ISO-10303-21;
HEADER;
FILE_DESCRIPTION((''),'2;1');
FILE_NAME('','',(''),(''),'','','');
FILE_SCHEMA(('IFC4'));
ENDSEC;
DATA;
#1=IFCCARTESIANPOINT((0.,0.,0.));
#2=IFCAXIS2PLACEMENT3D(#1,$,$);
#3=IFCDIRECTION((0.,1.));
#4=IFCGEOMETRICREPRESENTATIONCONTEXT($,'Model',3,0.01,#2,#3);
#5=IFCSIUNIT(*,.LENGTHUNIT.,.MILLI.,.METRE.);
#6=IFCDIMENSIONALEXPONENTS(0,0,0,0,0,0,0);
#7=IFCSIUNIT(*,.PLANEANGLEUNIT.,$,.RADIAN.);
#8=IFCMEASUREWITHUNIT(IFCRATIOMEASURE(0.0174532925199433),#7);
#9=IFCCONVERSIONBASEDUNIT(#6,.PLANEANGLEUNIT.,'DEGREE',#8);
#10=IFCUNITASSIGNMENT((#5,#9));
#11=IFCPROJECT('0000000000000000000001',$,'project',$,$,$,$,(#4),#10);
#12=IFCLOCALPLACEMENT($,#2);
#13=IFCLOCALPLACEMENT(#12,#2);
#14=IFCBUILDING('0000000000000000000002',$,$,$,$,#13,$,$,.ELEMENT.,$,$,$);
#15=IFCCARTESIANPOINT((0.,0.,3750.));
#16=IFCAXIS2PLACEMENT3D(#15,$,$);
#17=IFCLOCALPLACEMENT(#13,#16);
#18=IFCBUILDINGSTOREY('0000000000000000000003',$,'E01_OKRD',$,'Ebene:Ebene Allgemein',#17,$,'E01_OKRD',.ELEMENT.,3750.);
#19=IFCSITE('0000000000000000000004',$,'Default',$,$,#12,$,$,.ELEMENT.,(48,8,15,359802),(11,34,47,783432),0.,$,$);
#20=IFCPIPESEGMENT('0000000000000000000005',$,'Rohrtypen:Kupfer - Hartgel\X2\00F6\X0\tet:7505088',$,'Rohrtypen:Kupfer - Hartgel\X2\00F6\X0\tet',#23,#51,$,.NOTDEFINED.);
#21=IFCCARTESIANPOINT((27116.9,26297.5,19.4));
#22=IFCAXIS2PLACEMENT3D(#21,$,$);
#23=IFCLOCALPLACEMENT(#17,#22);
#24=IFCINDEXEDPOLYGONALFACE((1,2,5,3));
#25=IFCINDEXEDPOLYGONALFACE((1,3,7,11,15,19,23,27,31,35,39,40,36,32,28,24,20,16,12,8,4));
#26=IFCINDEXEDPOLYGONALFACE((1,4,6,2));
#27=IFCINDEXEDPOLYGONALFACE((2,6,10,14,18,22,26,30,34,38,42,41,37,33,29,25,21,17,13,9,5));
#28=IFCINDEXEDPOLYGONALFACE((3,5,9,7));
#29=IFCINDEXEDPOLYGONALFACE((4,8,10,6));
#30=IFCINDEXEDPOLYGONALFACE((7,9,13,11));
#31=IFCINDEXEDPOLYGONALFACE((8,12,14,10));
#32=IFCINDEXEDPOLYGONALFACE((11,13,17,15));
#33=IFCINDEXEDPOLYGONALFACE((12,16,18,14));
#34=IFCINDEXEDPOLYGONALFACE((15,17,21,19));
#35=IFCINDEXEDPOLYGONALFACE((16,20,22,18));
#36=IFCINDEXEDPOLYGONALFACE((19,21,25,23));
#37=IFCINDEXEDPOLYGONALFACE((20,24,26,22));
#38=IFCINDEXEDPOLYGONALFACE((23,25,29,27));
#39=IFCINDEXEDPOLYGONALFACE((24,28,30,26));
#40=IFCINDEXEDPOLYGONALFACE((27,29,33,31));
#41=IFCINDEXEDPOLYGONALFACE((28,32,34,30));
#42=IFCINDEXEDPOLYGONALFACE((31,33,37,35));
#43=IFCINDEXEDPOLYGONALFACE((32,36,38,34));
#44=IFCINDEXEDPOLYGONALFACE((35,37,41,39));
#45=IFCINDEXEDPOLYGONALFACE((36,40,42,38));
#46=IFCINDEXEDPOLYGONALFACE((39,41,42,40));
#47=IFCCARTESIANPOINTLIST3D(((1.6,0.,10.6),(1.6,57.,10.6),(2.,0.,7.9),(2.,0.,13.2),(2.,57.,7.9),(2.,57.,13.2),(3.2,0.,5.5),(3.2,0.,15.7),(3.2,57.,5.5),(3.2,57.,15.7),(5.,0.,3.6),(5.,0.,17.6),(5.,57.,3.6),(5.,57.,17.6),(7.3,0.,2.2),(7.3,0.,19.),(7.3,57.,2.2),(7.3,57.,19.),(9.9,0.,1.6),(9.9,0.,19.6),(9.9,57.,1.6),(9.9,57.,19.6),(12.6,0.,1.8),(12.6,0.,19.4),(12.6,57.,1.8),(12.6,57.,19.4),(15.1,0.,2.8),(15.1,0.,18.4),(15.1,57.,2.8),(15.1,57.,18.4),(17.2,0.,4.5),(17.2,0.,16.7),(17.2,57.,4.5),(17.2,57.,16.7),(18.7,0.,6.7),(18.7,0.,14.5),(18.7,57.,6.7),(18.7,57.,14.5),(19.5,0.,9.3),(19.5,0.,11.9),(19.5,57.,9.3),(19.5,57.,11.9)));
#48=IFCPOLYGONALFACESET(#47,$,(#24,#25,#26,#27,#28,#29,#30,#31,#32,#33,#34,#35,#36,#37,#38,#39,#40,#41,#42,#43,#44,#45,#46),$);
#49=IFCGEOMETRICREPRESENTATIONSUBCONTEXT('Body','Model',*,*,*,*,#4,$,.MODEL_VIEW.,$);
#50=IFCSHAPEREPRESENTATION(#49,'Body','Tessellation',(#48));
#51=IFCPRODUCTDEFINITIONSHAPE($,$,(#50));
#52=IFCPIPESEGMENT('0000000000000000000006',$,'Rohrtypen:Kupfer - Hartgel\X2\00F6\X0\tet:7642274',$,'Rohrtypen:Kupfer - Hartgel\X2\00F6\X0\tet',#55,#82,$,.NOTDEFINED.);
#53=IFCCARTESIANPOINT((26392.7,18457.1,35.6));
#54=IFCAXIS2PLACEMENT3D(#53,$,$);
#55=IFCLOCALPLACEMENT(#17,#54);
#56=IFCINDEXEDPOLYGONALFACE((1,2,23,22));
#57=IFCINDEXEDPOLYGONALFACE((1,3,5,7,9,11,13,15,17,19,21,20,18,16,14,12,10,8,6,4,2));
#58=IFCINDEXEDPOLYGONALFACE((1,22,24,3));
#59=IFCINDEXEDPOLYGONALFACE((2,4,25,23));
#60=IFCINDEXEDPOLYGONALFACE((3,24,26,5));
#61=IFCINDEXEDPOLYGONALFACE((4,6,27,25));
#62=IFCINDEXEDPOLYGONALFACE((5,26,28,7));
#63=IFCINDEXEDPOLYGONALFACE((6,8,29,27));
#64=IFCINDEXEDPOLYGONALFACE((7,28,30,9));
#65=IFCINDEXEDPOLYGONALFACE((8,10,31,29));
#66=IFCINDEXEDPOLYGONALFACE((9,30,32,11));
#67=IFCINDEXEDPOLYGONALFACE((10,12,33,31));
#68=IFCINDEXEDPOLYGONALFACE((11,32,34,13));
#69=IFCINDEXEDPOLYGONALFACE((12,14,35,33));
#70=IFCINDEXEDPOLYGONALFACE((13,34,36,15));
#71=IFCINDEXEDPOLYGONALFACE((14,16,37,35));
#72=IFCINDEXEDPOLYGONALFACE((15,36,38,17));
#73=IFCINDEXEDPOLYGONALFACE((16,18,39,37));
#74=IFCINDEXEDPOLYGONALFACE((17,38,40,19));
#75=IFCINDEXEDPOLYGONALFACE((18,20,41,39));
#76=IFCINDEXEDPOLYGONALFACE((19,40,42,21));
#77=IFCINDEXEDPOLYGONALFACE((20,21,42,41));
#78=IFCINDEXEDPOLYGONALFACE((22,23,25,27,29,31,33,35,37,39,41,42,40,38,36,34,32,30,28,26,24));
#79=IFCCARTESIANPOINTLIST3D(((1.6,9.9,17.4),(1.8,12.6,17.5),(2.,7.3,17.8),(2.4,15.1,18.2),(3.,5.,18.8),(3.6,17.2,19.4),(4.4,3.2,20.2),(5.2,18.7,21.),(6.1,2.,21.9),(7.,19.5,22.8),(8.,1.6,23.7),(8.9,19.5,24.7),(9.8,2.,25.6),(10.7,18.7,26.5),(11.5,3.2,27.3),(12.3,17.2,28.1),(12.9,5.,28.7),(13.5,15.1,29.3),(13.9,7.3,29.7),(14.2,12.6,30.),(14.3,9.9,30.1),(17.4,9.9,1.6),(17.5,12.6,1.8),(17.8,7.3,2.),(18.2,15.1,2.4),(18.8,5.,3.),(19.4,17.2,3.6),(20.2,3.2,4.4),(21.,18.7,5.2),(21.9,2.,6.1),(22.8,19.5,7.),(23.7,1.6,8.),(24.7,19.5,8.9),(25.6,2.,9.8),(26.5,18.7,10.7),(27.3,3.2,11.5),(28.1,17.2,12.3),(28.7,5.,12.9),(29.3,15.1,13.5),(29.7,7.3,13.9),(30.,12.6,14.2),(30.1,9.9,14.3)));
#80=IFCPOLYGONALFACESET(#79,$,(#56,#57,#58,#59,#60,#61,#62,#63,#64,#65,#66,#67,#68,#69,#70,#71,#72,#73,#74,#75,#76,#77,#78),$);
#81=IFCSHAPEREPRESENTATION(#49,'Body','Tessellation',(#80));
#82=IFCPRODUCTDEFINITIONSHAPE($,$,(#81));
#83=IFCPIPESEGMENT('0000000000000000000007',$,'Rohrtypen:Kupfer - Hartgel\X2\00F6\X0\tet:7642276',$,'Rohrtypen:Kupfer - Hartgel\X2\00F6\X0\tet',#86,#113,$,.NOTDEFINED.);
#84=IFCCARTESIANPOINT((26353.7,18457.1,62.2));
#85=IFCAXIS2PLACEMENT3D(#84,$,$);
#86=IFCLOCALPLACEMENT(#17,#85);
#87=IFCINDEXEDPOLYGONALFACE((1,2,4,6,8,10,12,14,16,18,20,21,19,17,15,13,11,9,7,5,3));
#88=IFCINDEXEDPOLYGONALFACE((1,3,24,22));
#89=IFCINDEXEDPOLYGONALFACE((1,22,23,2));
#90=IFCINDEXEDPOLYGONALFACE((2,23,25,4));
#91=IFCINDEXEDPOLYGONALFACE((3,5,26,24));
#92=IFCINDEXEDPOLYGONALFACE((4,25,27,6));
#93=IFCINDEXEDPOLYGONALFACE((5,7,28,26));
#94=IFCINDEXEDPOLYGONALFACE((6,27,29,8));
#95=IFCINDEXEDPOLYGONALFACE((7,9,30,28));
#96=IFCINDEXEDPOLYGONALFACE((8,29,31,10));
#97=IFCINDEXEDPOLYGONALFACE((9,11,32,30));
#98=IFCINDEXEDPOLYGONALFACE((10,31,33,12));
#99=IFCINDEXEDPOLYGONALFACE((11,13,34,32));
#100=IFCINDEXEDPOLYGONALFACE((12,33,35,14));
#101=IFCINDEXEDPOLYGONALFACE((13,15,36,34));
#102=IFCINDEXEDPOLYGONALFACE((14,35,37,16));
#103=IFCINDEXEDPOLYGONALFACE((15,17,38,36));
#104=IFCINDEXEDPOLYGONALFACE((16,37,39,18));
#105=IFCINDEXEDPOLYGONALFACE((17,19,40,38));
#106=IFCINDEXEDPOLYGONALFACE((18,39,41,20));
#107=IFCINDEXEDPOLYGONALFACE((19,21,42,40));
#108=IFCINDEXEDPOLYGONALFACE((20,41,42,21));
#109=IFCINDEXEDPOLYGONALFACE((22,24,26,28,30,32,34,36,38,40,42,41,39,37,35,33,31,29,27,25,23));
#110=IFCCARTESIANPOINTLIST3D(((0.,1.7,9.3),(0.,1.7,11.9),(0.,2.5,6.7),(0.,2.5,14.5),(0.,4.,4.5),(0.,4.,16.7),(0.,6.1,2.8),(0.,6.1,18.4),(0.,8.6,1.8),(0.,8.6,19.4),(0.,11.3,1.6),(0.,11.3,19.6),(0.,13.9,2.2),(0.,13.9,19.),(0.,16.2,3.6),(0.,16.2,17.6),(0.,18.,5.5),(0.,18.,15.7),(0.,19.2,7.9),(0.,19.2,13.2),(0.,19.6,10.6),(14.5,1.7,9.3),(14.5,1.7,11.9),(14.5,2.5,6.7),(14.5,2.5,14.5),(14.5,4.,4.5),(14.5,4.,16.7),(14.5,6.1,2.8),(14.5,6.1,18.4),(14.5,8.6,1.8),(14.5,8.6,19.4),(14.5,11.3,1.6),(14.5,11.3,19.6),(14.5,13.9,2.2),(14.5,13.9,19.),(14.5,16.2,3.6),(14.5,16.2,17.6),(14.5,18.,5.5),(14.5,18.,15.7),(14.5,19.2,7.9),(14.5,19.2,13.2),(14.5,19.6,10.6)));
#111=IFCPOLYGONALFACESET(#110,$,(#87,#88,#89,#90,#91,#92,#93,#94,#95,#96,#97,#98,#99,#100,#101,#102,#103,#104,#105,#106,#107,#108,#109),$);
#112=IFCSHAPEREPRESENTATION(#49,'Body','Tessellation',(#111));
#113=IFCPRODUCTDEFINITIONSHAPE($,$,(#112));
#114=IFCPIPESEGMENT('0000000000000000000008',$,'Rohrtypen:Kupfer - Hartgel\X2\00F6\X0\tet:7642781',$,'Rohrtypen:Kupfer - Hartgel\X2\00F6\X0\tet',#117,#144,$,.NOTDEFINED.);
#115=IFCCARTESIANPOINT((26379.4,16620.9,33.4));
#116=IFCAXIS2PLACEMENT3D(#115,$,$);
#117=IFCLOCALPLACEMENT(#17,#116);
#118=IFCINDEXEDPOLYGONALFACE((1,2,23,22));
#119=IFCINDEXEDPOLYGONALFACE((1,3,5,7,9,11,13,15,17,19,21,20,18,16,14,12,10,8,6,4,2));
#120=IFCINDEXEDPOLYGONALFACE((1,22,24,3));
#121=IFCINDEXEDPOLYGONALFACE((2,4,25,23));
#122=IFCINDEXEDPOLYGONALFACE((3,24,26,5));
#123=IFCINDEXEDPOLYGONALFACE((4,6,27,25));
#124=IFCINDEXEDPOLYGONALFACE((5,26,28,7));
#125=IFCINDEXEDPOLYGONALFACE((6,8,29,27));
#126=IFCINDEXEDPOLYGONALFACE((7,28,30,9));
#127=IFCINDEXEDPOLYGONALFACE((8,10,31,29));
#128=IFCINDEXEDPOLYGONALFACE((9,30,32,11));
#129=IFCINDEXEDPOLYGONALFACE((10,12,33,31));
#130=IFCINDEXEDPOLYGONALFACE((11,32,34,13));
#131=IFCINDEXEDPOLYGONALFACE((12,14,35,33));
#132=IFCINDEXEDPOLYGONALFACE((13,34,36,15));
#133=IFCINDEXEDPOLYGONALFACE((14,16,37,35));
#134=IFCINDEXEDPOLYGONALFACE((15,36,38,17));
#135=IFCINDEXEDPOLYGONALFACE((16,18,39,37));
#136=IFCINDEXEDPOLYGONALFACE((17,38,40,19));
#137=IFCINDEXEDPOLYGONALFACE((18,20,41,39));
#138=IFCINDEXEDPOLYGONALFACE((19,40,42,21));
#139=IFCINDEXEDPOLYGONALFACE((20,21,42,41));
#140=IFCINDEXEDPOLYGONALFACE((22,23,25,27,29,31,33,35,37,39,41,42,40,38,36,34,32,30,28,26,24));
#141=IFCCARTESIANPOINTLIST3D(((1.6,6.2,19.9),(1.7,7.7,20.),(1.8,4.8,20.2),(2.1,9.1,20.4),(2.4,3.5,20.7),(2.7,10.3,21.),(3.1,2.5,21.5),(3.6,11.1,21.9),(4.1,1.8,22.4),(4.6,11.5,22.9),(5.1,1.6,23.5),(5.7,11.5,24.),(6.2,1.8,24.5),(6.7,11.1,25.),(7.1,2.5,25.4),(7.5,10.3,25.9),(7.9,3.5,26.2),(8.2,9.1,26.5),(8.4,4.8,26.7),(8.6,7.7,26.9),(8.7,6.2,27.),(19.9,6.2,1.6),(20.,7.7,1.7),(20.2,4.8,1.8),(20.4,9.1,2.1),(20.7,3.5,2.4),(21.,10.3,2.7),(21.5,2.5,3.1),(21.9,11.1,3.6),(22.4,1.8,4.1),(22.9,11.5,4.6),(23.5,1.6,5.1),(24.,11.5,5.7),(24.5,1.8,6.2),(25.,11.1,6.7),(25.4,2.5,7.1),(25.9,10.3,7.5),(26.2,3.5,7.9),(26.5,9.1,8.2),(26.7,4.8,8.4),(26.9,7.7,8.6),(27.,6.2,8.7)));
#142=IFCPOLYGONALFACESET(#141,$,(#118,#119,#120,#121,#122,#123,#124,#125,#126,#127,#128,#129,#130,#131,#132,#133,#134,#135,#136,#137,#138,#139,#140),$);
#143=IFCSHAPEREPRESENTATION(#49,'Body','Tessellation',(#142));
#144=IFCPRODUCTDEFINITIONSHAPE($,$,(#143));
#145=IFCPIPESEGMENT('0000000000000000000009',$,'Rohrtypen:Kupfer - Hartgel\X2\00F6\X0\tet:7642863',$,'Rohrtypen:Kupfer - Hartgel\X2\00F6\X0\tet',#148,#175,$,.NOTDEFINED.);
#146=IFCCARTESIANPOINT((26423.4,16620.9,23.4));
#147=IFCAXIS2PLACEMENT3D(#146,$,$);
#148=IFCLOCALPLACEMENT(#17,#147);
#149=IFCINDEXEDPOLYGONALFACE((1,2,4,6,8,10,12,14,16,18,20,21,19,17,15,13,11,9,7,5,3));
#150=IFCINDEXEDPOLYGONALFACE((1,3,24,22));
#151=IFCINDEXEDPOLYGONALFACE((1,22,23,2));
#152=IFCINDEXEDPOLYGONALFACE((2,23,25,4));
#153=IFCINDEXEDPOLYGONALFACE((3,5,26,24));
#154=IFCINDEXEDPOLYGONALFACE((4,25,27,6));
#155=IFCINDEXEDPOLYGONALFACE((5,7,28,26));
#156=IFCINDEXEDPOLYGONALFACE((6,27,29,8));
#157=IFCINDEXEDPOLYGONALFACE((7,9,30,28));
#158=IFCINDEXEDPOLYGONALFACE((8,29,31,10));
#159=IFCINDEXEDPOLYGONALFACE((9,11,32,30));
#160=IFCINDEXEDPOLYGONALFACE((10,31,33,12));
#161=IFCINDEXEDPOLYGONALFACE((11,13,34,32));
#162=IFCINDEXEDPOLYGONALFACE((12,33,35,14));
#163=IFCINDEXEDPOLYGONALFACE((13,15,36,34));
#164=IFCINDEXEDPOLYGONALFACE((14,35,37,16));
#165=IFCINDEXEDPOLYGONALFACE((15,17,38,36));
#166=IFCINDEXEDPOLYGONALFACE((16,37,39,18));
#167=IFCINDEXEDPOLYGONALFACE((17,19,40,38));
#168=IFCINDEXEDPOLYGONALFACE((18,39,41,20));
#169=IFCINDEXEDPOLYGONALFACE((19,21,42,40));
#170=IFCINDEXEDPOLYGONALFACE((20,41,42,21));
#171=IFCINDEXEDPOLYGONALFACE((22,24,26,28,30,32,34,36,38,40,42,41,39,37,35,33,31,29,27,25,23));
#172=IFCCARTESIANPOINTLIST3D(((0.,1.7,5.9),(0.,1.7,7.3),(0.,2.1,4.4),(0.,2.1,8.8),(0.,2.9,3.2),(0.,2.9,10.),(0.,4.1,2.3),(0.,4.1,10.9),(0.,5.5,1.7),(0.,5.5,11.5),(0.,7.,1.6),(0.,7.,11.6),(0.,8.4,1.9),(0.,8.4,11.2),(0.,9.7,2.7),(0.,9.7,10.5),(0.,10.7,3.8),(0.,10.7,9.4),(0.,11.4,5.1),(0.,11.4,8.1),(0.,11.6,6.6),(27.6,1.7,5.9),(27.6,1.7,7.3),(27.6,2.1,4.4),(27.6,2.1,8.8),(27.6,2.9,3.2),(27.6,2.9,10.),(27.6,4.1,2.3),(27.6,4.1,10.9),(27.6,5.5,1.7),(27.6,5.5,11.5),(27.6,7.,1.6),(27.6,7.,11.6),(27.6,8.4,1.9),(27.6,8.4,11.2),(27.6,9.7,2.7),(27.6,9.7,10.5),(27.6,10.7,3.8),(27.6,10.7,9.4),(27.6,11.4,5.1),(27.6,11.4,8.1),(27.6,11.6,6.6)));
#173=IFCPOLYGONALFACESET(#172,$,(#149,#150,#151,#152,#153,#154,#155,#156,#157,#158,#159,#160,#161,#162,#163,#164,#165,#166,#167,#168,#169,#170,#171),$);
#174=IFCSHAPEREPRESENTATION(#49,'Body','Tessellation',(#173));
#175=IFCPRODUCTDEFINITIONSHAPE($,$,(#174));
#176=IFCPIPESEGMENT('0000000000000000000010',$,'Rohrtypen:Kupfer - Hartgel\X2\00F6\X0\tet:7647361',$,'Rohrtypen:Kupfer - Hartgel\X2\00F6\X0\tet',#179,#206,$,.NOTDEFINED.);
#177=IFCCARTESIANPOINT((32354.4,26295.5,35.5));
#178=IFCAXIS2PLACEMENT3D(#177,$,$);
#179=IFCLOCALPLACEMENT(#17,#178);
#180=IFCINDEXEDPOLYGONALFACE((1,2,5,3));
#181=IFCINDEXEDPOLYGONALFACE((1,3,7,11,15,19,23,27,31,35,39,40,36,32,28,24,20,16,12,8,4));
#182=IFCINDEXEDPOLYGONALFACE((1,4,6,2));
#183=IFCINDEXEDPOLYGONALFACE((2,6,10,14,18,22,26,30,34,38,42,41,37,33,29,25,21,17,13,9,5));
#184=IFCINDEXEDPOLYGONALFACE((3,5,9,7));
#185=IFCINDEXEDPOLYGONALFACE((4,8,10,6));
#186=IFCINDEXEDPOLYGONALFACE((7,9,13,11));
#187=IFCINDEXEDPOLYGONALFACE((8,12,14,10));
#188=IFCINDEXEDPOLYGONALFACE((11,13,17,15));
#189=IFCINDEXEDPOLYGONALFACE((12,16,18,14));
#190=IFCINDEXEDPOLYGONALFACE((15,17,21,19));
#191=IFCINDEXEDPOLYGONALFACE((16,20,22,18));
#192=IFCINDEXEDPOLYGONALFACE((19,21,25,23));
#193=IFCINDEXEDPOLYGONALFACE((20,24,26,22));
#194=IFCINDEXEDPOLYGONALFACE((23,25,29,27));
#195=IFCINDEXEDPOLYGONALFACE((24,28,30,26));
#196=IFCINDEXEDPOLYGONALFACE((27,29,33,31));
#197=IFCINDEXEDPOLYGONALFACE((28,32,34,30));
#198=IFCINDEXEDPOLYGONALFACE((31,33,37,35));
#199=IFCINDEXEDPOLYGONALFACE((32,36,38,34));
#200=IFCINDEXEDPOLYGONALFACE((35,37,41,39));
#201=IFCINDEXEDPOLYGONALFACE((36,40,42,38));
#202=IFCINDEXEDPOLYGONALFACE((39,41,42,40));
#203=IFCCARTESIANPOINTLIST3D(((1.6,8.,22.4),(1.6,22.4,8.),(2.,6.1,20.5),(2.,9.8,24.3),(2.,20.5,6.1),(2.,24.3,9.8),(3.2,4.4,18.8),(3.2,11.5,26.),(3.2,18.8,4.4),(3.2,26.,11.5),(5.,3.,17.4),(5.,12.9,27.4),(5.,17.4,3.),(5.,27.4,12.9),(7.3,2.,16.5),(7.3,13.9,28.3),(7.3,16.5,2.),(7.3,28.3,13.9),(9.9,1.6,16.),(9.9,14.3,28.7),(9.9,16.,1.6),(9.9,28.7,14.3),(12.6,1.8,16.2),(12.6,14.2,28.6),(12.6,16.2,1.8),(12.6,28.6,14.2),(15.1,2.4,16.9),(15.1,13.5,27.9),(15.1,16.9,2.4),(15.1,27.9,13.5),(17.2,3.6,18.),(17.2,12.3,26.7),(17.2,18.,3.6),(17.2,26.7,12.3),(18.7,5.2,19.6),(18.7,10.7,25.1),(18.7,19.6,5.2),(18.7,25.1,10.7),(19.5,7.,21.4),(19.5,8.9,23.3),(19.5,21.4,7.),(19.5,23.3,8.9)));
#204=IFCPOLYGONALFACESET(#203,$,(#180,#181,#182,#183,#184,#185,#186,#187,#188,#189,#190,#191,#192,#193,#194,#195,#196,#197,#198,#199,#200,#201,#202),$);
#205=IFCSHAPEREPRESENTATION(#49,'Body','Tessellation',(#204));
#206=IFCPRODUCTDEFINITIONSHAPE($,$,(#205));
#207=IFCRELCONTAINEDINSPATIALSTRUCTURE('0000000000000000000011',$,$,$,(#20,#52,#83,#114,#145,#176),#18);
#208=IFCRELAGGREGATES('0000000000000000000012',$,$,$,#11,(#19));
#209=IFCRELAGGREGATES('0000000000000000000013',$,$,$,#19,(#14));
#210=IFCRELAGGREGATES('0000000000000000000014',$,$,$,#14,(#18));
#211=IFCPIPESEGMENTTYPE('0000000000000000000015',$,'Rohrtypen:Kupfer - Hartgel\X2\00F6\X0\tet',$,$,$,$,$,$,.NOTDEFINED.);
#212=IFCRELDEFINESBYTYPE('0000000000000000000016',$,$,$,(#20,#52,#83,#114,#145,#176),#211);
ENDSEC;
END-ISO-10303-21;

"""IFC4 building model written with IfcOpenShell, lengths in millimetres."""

from ifc_helpers import new_model, entity, si_unit, converted_unit, direction, frame, frame_2d, origin, origin_2d_with_axis, place, context, subcontext, project, spatial, circle, extrude, type_object, element, save


model = new_model("IFC4")

# Units and contexts
model_context = context("Model", 3, precision=0.01, world=origin(), true_north=direction((0.0, 1.0)))
body_context = subcontext(model_context, "Body", "Model", "MODEL_VIEW")
ifc_project = project(units=[si_unit("LENGTHUNIT", "METRE", prefix="MILLI"), converted_unit("PLANEANGLEUNIT", "DEGREE", entity("IfcRatioMeasure", 0.0174532925199433), si_unit("PLANEANGLEUNIT", "RADIAN"), dimensions=[0, 0, 0, 0, 0, 0, 0])], contexts=[model_context])

# Site, building, storey
site_placement = place(None, origin())
site = spatial("IfcSite", under=ifc_project, at=site_placement, Name="Default", CompositionType="ELEMENT", RefLatitude=(48, 8, 15, 359802), RefLongitude=(11, 34, 47, 783432), RefElevation=0.0)
building_placement = place(site_placement, origin())
building = spatial("IfcBuilding", under=site, at=building_placement, CompositionType="ELEMENT")
storey_placement = place(building_placement, frame((0.0, 0.0, 3750.0)))
storey = spatial("IfcBuildingStorey", under=building, at=storey_placement, Name="E01_OKRD", ObjectType="Ebene:Ebene Allgemein", LongName="E01_OKRD", CompositionType="ELEMENT", Elevation=3750.0)

# Pipe segments
pipe_segment_type = type_object("IfcPipeSegmentType", Name="Rohrtypen:Kupfer - Hartgelötet", PredefinedType="NOTDEFINED")
pipe_segment_1_placement = place(storey_placement, frame((27116.9, 26297.5, 19.4)))
element("IfcPipeSegment", 1, at=pipe_segment_1_placement, inside=storey, type_object=pipe_segment_type, Name="Rohrtypen:Kupfer - Hartgelötet:7505088", ObjectType="Rohrtypen:Kupfer - Hartgelötet", PredefinedType="NOTDEFINED", context=body_context, shape_type="SweptSolid", body=[
    extrude(circle(Radius=9.0, at=origin_2d_with_axis()), frame((10.6, 0.0, 10.6), z_axis=(0.0, 1.0, 0.0), x_axis=(-1.0, 0.0, 0.0)), (0.0, 0.0, 1.0), 57.0),
])
pipe_segment_2_placement = place(storey_placement, frame((26392.7, 18457.1, 35.6)))
element("IfcPipeSegment", 2, at=pipe_segment_2_placement, inside=storey, type_object=pipe_segment_type, Name="Rohrtypen:Kupfer - Hartgelötet:7642274", ObjectType="Rohrtypen:Kupfer - Hartgelötet", PredefinedType="NOTDEFINED", context=body_context, shape_type="SweptSolid", body=[
    extrude(circle(Radius=9.0, at=frame_2d((0.0, 0.0), x_axis=(1.0, 0.0))), frame((23.7, 10.6, 8.0), z_axis=(-0.707107, 0.0, 0.707107), x_axis=(0.0, -1.0, 0.0)), (0.0, 0.0, 1.0), 22.3),
])
pipe_segment_3_placement = place(storey_placement, frame((26353.7, 18457.1, 62.2)))
element("IfcPipeSegment", 3, at=pipe_segment_3_placement, inside=storey, type_object=pipe_segment_type, Name="Rohrtypen:Kupfer - Hartgelötet:7642276", ObjectType="Rohrtypen:Kupfer - Hartgelötet", PredefinedType="NOTDEFINED", context=body_context, shape_type="SweptSolid", body=[
    extrude(circle(Radius=9.0, at=origin_2d_with_axis()), frame((0.0, 10.6, 10.6), z_axis=(1.0, 0.0, 0.0), x_axis=(0.0, 1.0, 0.0)), (0.0, 0.0, 1.0), 14.5),
])
pipe_segment_4_placement = place(storey_placement, frame((26379.4, 16620.9, 33.4)))
element("IfcPipeSegment", 4, at=pipe_segment_4_placement, inside=storey, type_object=pipe_segment_type, Name="Rohrtypen:Kupfer - Hartgelötet:7642781", ObjectType="Rohrtypen:Kupfer - Hartgelötet", PredefinedType="NOTDEFINED", context=body_context, shape_type="SweptSolid", body=[
    extrude(circle(Radius=5.0, at=frame_2d((0.0, 0.0), x_axis=(1.0, 0.0))), frame((5.1, 6.6, 23.5), z_axis=(0.707107, 0.0, -0.707107), x_axis=(0.0, -1.0, 0.0)), (0.0, 0.0, 1.0), 25.9),
])
pipe_segment_5_placement = place(storey_placement, frame((26423.4, 16620.9, 23.4)))
element("IfcPipeSegment", 5, at=pipe_segment_5_placement, inside=storey, type_object=pipe_segment_type, Name="Rohrtypen:Kupfer - Hartgelötet:7642863", ObjectType="Rohrtypen:Kupfer - Hartgelötet", PredefinedType="NOTDEFINED", context=body_context, shape_type="SweptSolid", body=[
    extrude(circle(Radius=5.0, at=origin_2d_with_axis()), frame((0.0, 6.6, 6.6), z_axis=(1.0, 0.0, 0.0), x_axis=(0.0, 1.0, 0.0)), (0.0, 0.0, 1.0), 27.6),
])
pipe_segment_6_placement = place(storey_placement, frame((32354.4, 26295.5, 35.5)))
element("IfcPipeSegment", 6, at=pipe_segment_6_placement, inside=storey, type_object=pipe_segment_type, Name="Rohrtypen:Kupfer - Hartgelötet:7647361", ObjectType="Rohrtypen:Kupfer - Hartgelötet", PredefinedType="NOTDEFINED", context=body_context, shape_type="SweptSolid", body=[
    extrude(circle(Radius=9.0, at=origin_2d_with_axis()), frame((10.6, 22.4, 8.0), z_axis=(0.0, -0.707107, 0.707107), x_axis=(-1.0, 0.0, 0.0)), (0.0, 0.0, 1.0), 20.4),
])

save(model, "model.ifc")
